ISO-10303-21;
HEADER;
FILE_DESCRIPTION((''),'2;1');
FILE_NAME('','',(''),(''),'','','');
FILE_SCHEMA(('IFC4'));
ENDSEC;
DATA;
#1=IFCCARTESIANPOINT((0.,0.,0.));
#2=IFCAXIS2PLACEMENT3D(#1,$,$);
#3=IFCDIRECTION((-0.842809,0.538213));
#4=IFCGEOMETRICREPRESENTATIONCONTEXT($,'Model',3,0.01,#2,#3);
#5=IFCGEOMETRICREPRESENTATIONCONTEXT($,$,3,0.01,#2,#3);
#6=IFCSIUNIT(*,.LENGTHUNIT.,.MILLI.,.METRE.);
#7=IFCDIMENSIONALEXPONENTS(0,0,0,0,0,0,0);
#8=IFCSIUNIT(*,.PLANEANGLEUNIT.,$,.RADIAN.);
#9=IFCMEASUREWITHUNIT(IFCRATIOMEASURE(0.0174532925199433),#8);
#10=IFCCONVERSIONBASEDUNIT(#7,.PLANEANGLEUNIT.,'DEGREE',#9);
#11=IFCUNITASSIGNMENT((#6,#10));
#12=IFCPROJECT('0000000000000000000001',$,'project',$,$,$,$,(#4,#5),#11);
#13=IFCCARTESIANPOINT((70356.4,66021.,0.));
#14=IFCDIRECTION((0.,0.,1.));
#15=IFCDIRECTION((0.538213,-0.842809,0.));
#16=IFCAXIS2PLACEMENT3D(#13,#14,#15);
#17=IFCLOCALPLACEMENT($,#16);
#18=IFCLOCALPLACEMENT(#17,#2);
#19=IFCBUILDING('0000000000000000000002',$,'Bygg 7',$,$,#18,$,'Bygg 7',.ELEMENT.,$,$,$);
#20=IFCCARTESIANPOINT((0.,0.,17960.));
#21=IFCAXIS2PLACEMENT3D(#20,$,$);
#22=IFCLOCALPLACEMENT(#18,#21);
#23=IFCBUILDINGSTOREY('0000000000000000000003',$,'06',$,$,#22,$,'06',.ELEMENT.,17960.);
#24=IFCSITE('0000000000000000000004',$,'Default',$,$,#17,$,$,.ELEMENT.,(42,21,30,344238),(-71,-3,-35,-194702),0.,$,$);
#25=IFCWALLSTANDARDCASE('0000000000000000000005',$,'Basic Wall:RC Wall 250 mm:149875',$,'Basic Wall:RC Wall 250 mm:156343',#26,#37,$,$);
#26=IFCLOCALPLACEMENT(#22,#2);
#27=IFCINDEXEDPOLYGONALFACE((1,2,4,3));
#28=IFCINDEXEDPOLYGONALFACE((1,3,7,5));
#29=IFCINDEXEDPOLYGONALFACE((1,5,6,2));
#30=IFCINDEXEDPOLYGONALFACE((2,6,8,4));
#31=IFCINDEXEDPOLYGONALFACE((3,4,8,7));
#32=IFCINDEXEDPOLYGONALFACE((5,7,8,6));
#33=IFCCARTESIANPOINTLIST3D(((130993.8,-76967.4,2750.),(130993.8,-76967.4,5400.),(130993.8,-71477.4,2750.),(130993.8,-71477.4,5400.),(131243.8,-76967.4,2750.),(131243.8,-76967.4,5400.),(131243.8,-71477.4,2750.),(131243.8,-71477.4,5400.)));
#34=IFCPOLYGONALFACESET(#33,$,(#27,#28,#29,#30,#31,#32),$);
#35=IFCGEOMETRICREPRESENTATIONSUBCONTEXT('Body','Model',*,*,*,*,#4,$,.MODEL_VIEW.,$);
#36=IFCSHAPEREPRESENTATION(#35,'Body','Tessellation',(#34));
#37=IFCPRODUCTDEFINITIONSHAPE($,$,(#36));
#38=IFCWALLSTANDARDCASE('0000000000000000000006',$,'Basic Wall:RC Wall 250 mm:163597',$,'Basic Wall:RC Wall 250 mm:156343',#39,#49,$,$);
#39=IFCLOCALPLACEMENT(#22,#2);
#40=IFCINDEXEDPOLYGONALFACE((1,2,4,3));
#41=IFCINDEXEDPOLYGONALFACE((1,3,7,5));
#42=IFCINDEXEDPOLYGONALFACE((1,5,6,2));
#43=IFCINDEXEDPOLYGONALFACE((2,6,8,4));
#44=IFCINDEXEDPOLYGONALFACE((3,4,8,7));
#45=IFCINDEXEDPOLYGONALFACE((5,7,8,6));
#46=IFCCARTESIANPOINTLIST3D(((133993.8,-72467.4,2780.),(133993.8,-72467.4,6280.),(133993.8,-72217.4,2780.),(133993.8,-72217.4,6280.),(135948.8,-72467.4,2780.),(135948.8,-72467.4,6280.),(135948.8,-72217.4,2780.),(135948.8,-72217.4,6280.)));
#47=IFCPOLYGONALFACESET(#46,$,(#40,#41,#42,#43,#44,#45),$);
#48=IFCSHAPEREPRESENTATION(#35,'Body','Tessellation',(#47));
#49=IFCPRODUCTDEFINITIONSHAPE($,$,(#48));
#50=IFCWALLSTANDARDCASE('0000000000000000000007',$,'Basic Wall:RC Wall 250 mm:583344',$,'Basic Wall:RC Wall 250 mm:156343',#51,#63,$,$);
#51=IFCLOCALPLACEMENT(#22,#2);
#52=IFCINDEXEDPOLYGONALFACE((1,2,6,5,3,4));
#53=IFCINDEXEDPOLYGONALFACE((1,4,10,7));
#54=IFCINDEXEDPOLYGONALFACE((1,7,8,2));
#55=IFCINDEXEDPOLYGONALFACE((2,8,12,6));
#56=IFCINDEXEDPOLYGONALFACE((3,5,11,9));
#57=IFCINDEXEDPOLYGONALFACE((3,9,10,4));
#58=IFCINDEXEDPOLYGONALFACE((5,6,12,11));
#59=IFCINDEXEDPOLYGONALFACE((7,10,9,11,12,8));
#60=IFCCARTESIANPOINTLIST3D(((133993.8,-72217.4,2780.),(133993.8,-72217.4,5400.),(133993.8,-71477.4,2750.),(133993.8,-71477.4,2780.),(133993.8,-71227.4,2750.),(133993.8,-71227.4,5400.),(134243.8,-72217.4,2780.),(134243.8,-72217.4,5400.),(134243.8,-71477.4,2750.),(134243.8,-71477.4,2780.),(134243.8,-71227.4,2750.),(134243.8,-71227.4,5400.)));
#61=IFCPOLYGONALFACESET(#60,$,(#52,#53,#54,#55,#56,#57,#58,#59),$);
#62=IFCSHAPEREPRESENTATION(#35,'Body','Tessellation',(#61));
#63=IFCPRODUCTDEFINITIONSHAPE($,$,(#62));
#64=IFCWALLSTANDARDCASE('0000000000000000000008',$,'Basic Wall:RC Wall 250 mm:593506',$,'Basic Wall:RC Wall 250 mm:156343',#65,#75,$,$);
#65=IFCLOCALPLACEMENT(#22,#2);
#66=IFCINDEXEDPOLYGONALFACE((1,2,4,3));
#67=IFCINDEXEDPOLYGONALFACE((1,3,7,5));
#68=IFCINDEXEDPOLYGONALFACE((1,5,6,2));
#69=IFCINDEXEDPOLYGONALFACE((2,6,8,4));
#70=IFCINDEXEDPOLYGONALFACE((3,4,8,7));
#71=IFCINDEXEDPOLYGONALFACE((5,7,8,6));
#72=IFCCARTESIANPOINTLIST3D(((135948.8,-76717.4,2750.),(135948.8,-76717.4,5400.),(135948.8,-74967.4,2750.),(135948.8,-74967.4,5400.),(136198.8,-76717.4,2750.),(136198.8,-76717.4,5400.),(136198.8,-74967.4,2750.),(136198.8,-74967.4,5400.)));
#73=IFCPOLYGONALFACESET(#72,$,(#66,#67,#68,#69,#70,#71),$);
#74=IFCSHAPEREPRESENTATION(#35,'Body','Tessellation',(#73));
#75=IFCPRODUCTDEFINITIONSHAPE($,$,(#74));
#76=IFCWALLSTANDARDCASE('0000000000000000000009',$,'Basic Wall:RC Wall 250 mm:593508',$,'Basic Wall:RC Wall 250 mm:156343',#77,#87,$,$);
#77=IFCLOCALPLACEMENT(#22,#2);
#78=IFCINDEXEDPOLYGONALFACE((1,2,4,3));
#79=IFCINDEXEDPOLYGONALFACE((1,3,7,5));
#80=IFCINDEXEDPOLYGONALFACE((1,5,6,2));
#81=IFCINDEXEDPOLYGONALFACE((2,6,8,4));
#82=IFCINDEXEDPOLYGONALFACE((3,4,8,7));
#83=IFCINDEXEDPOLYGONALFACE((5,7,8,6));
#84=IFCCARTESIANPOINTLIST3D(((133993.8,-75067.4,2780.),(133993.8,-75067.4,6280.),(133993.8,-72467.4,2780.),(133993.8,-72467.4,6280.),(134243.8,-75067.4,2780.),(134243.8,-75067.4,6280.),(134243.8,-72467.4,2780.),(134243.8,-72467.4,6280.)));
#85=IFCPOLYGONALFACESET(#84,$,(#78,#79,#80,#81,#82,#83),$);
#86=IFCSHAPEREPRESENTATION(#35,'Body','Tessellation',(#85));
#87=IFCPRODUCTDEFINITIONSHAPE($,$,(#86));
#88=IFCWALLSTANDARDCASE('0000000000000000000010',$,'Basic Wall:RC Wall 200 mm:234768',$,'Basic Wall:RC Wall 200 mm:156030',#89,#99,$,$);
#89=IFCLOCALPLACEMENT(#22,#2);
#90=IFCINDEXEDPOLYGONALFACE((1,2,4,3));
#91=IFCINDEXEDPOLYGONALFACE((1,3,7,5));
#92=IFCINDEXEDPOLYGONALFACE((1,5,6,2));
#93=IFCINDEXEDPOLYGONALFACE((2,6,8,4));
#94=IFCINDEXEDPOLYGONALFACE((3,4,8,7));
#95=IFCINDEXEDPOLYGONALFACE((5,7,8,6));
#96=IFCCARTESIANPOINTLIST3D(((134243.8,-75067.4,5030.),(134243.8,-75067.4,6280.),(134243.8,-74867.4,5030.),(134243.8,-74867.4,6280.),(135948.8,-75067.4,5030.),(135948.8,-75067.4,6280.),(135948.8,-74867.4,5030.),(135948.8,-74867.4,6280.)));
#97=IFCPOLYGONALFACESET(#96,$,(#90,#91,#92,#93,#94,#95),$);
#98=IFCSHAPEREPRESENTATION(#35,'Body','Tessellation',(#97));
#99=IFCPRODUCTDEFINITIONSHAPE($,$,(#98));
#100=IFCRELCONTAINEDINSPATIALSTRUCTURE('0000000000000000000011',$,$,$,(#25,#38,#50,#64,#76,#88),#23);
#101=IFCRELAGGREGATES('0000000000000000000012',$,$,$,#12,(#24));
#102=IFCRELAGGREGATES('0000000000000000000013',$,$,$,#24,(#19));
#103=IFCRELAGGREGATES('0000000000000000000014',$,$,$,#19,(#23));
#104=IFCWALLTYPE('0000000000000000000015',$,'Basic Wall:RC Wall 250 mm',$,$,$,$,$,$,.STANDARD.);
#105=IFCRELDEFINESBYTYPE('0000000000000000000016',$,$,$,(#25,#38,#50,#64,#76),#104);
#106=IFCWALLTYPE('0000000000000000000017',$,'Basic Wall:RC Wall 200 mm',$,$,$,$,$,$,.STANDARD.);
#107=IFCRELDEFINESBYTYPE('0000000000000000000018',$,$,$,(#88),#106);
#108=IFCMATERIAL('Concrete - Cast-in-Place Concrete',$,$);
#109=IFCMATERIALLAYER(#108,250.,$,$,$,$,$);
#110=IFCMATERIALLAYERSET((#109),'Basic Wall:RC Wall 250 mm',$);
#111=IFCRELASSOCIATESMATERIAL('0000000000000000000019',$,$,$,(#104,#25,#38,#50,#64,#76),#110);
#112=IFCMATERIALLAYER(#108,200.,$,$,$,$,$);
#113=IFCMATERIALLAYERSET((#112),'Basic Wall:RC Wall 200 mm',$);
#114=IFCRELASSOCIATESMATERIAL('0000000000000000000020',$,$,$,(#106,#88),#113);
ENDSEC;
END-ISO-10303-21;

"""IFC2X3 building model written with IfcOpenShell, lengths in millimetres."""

from ifc_helpers import new_model, entity, si_unit, converted_unit, direction, frame, frame_2d, origin, place, context, subcontext, project, spatial, polyline, rectangle, extrude, clip, bounded_halfspace, material, layer, layer_set, layer_usage, type_object, element, save


model = new_model("IFC2X3")

# Units and contexts
model_context = context("Model", 3, precision=0.01, world=origin(), true_north=direction((-0.842809, 0.538213)))
context_of_model = context(None, 3, precision=0.01, world=origin(), true_north=direction((-0.842809, 0.538213)))
body_context = subcontext(model_context, "Body", "Model", "MODEL_VIEW")
ifc_project = project(units=[si_unit("LENGTHUNIT", "METRE", prefix="MILLI"), converted_unit("PLANEANGLEUNIT", "DEGREE", entity("IfcRatioMeasure", 0.0174532925199433), si_unit("PLANEANGLEUNIT", "RADIAN"), dimensions=[0, 0, 0, 0, 0, 0, 0])], contexts=[model_context, context_of_model])

# Site, building, storey
site_placement = place(None, frame((70356.4, 66021.0, 0.0), z_axis=(0.0, 0.0, 1.0), x_axis=(0.538213, -0.842809, 0.0)))
site = spatial("IfcSite", under=ifc_project, at=site_placement, Name="Default", CompositionType="ELEMENT", RefLatitude=(42, 21, 30, 344238), RefLongitude=(-71, -3, -35, -194702), RefElevation=0.0)
building_placement = place(site_placement, origin())
building = spatial("IfcBuilding", under=site, at=building_placement, Name="Bygg 7", LongName="Bygg 7", CompositionType="ELEMENT")
storey_placement = place(building_placement, frame((0.0, 0.0, 17960.0)))
storey = spatial("IfcBuildingStorey", under=building, at=storey_placement, Name="06", LongName="06", CompositionType="ELEMENT", Elevation=17960.0)

# Shared definitions
ifc_material_1 = material(Name="Concrete - Cast-in-Place Concrete")

# Shared definitions
ifc_layer_1 = layer(ifc_material_1, 250.0)
ifc_layer_set_1 = layer_set([ifc_layer_1], Name="Basic Wall:RC Wall 250 mm")
wall_type_1 = type_object("IfcWallType", Name="Basic Wall:RC Wall 250 mm", PredefinedType="STANDARD", material=ifc_layer_set_1)

# Walls
ifc_layer_usage_1 = layer_usage(ifc_layer_set_1, "AXIS2", "NEGATIVE", 125.0)
wall_1_placement = place(storey_placement, frame((131118.8, -76967.4, 2750.0), z_axis=(0.0, 0.0, 1.0), x_axis=(0.0, 1.0, 0.0)))
element("IfcWallStandardCase", 1, at=wall_1_placement, inside=storey, type_object=wall_type_1, material=ifc_layer_usage_1, Name="Basic Wall:RC Wall 250 mm:149875", ObjectType="Basic Wall:RC Wall 250 mm:156343", context=body_context, shape_type="Clipping", body=[
    clip(clip(extrude(rectangle(XDim=5490.0, YDim=250.0, at=frame_2d((2745.0, 0.0), x_axis=(-1.0, 0.0))), origin(), (0.0, 0.0, 1.0), 2650.0), bounded_halfspace(frame((5490.0, -125.0, 0.0), z_axis=(0.0, 0.0, 1.0), x_axis=(0.99571, 0.092529, 0.0)), True, frame((5490.0, -125.0, 0.0)), polyline([(0.0, 0.0), (0.0, 250.0), (-5490.0, 250.0), (-5490.0, 0.0), (-5240.0, 0.0), (0.0, 0.0)]))), bounded_halfspace(frame((0.0, -125.0, 2650.0), z_axis=(0.0, 0.0, -1.0), x_axis=(0.0, 1.0, 0.0)), True, frame((0.0, -125.0, 2650.0)), polyline([(0.0, 0.0), (250.0, 0.0), (5490.0, 0.0), (5490.0, 250.0), (0.0, 250.0), (0.0, 0.0)]))),
])
ifc_layer_usage_2 = layer_usage(ifc_layer_set_1, "AXIS2", "POSITIVE", -125.0)
wall_2_placement = place(storey_placement, frame((133993.8, -72342.4, 2780.0)))
element("IfcWallStandardCase", 2, at=wall_2_placement, inside=storey, type_object=wall_type_1, material=ifc_layer_usage_2, Name="Basic Wall:RC Wall 250 mm:163597", ObjectType="Basic Wall:RC Wall 250 mm:156343", context=body_context, shape_type="Clipping", body=[
    clip(extrude(rectangle(XDim=1955.0, YDim=250.0, at=frame_2d((977.5, 0.0), x_axis=(-1.0, 0.0))), origin(), (0.0, 0.0, 1.0), 3500.0), bounded_halfspace(frame((0.0, -125.0, 3500.0), z_axis=(0.0, 0.0, -1.0), x_axis=(1.0, 0.0, 0.0)), True, frame((0.0, -125.0, 3500.0)), polyline([(0.0, 0.0), (250.0, 0.0), (1955.0, 0.0), (1955.0, 250.0), (0.0, 250.0), (0.0, 0.0)]))),
])
ifc_layer_usage_3 = layer_usage(ifc_layer_set_1, "AXIS2", "NEGATIVE", 125.0)
wall_3_placement = place(storey_placement, frame((134118.8, -72217.4, 2750.0), z_axis=(0.0, 0.0, 1.0), x_axis=(0.0, 1.0, 0.0)))
element("IfcWallStandardCase", 3, at=wall_3_placement, inside=storey, type_object=wall_type_1, material=ifc_layer_usage_3, Name="Basic Wall:RC Wall 250 mm:583344", ObjectType="Basic Wall:RC Wall 250 mm:156343", context=body_context, shape_type="Clipping", body=[
    clip(clip(clip(extrude(rectangle(XDim=990.0, YDim=250.0, at=frame_2d((495.0, 0.0), x_axis=(-1.0, 0.0))), origin(), (0.0, 0.0, 1.0), 2650.0), bounded_halfspace(frame((990.0, 125.0, 0.0), z_axis=(0.0, 0.0, 1.0), x_axis=(0.99571, 0.092529, 0.0)), True, frame((990.0, 125.0, 0.0)), polyline([(0.0, 0.0), (-250.0, 0.0), (-250.0, -250.0), (0.0, -250.0), (0.0, 0.0)]))), bounded_halfspace(frame((990.0, 125.0, 2650.0), z_axis=(0.0, 0.0, -1.0), x_axis=(-1.0, 0.0, 0.0)), True, frame((990.0, 125.0, 2650.0)), polyline([(0.0, 0.0), (-250.0, 0.0), (-990.0, 0.0), (-990.0, -250.0), (-529.0, -250.0), (0.0, -250.0), (0.0, 0.0)]))), bounded_halfspace(frame((740.0, -125.0, 30.0), z_axis=(0.0, 0.0, -1.0), x_axis=(0.0, 1.0, 0.0)), False, frame((740.0, -125.0, 30.0)), polyline([(0.0, 0.0), (0.0, 250.0), (-740.0, 250.0), (-740.0, 0.0), (0.0, 0.0)]))),
])
ifc_layer_usage_4 = layer_usage(ifc_layer_set_1, "AXIS2", "NEGATIVE", 125.0)
wall_4_placement = place(storey_placement, frame((136073.8, -76717.4, 2750.0), z_axis=(0.0, 0.0, 1.0), x_axis=(0.0, 1.0, 0.0)))
element("IfcWallStandardCase", 4, at=wall_4_placement, inside=storey, type_object=wall_type_1, material=ifc_layer_usage_4, Name="Basic Wall:RC Wall 250 mm:593506", ObjectType="Basic Wall:RC Wall 250 mm:156343", context=body_context, shape_type="Clipping", body=[
    clip(clip(extrude(rectangle(XDim=1750.0, YDim=250.0, at=frame_2d((875.0, 0.0), x_axis=(-1.0, 0.0))), origin(), (0.0, 0.0, 1.0), 2650.0), bounded_halfspace(frame((1750.0, -125.0, 0.0), z_axis=(0.0, 0.0, 1.0), x_axis=(0.99571, 0.092529, 0.0)), True, frame((1750.0, -125.0, 0.0)), polyline([(0.0, 0.0), (0.0, 250.0), (-1750.0, 250.0), (-1750.0, 0.0), (0.0, 0.0)]))), bounded_halfspace(frame((0.0, -125.0, 2650.0), z_axis=(0.0, 0.0, -1.0), x_axis=(0.0, 1.0, 0.0)), True, frame((0.0, -125.0, 2650.0)), polyline([(0.0, 0.0), (1650.0, 0.0), (1650.0, 250.0), (0.0, 250.0), (0.0, 0.0)]))),
])
ifc_layer_usage_5 = layer_usage(ifc_layer_set_1, "AXIS2", "NEGATIVE", 125.0)
wall_5_placement = place(storey_placement, frame((134118.8, -75067.4, 2780.0), z_axis=(0.0, 0.0, 1.0), x_axis=(0.0, 1.0, 0.0)))
element("IfcWallStandardCase", 5, at=wall_5_placement, inside=storey, type_object=wall_type_1, material=ifc_layer_usage_5, Name="Basic Wall:RC Wall 250 mm:593508", ObjectType="Basic Wall:RC Wall 250 mm:156343", context=body_context, shape_type="Clipping", body=[
    clip(extrude(rectangle(XDim=2600.0, YDim=250.0, at=frame_2d((1300.0, 0.0), x_axis=(-1.0, 0.0))), origin(), (0.0, 0.0, 1.0), 3500.0), bounded_halfspace(frame((0.0, -125.0, 3500.0), z_axis=(0.0, 0.0, -1.0), x_axis=(0.0, -1.0, 0.0)), True, frame((0.0, -125.0, 3500.0)), polyline([(0.0, 0.0), (200.0, 0.0), (2600.0, 0.0), (2600.0, 250.0), (0.0, 250.0), (0.0, 0.0)]))),
])
ifc_layer_2 = layer(ifc_material_1, 200.0)
ifc_layer_set_2 = layer_set([ifc_layer_2], Name="Basic Wall:RC Wall 200 mm")
ifc_layer_usage_6 = layer_usage(ifc_layer_set_2, "AXIS2", "NEGATIVE", 100.0)
wall_type_2 = type_object("IfcWallType", Name="Basic Wall:RC Wall 200 mm", PredefinedType="STANDARD", material=ifc_layer_set_2)
wall_6_placement = place(storey_placement, frame((134243.8, -74967.4, 5030.0)))
element("IfcWallStandardCase", 6, at=wall_6_placement, inside=storey, type_object=wall_type_2, material=ifc_layer_usage_6, Name="Basic Wall:RC Wall 200 mm:234768", ObjectType="Basic Wall:RC Wall 200 mm:156030", context=body_context, shape_type="Clipping", body=[
    clip(extrude(rectangle(XDim=1705.0, YDim=200.0, at=frame_2d((852.5, 0.0), x_axis=(-1.0, 0.0))), origin(), (0.0, 0.0, 1.0), 1250.0), bounded_halfspace(frame((0.0, -100.0, 1250.0), z_axis=(0.0, 0.0, -1.0), x_axis=(1.0, 0.0, 0.0)), True, frame((0.0, -100.0, 1250.0)), polyline([(0.0, 0.0), (1705.0, 0.0), (1705.0, 200.0), (0.0, 200.0), (0.0, 0.0)]))),
])

save(model, "model.ifc")
